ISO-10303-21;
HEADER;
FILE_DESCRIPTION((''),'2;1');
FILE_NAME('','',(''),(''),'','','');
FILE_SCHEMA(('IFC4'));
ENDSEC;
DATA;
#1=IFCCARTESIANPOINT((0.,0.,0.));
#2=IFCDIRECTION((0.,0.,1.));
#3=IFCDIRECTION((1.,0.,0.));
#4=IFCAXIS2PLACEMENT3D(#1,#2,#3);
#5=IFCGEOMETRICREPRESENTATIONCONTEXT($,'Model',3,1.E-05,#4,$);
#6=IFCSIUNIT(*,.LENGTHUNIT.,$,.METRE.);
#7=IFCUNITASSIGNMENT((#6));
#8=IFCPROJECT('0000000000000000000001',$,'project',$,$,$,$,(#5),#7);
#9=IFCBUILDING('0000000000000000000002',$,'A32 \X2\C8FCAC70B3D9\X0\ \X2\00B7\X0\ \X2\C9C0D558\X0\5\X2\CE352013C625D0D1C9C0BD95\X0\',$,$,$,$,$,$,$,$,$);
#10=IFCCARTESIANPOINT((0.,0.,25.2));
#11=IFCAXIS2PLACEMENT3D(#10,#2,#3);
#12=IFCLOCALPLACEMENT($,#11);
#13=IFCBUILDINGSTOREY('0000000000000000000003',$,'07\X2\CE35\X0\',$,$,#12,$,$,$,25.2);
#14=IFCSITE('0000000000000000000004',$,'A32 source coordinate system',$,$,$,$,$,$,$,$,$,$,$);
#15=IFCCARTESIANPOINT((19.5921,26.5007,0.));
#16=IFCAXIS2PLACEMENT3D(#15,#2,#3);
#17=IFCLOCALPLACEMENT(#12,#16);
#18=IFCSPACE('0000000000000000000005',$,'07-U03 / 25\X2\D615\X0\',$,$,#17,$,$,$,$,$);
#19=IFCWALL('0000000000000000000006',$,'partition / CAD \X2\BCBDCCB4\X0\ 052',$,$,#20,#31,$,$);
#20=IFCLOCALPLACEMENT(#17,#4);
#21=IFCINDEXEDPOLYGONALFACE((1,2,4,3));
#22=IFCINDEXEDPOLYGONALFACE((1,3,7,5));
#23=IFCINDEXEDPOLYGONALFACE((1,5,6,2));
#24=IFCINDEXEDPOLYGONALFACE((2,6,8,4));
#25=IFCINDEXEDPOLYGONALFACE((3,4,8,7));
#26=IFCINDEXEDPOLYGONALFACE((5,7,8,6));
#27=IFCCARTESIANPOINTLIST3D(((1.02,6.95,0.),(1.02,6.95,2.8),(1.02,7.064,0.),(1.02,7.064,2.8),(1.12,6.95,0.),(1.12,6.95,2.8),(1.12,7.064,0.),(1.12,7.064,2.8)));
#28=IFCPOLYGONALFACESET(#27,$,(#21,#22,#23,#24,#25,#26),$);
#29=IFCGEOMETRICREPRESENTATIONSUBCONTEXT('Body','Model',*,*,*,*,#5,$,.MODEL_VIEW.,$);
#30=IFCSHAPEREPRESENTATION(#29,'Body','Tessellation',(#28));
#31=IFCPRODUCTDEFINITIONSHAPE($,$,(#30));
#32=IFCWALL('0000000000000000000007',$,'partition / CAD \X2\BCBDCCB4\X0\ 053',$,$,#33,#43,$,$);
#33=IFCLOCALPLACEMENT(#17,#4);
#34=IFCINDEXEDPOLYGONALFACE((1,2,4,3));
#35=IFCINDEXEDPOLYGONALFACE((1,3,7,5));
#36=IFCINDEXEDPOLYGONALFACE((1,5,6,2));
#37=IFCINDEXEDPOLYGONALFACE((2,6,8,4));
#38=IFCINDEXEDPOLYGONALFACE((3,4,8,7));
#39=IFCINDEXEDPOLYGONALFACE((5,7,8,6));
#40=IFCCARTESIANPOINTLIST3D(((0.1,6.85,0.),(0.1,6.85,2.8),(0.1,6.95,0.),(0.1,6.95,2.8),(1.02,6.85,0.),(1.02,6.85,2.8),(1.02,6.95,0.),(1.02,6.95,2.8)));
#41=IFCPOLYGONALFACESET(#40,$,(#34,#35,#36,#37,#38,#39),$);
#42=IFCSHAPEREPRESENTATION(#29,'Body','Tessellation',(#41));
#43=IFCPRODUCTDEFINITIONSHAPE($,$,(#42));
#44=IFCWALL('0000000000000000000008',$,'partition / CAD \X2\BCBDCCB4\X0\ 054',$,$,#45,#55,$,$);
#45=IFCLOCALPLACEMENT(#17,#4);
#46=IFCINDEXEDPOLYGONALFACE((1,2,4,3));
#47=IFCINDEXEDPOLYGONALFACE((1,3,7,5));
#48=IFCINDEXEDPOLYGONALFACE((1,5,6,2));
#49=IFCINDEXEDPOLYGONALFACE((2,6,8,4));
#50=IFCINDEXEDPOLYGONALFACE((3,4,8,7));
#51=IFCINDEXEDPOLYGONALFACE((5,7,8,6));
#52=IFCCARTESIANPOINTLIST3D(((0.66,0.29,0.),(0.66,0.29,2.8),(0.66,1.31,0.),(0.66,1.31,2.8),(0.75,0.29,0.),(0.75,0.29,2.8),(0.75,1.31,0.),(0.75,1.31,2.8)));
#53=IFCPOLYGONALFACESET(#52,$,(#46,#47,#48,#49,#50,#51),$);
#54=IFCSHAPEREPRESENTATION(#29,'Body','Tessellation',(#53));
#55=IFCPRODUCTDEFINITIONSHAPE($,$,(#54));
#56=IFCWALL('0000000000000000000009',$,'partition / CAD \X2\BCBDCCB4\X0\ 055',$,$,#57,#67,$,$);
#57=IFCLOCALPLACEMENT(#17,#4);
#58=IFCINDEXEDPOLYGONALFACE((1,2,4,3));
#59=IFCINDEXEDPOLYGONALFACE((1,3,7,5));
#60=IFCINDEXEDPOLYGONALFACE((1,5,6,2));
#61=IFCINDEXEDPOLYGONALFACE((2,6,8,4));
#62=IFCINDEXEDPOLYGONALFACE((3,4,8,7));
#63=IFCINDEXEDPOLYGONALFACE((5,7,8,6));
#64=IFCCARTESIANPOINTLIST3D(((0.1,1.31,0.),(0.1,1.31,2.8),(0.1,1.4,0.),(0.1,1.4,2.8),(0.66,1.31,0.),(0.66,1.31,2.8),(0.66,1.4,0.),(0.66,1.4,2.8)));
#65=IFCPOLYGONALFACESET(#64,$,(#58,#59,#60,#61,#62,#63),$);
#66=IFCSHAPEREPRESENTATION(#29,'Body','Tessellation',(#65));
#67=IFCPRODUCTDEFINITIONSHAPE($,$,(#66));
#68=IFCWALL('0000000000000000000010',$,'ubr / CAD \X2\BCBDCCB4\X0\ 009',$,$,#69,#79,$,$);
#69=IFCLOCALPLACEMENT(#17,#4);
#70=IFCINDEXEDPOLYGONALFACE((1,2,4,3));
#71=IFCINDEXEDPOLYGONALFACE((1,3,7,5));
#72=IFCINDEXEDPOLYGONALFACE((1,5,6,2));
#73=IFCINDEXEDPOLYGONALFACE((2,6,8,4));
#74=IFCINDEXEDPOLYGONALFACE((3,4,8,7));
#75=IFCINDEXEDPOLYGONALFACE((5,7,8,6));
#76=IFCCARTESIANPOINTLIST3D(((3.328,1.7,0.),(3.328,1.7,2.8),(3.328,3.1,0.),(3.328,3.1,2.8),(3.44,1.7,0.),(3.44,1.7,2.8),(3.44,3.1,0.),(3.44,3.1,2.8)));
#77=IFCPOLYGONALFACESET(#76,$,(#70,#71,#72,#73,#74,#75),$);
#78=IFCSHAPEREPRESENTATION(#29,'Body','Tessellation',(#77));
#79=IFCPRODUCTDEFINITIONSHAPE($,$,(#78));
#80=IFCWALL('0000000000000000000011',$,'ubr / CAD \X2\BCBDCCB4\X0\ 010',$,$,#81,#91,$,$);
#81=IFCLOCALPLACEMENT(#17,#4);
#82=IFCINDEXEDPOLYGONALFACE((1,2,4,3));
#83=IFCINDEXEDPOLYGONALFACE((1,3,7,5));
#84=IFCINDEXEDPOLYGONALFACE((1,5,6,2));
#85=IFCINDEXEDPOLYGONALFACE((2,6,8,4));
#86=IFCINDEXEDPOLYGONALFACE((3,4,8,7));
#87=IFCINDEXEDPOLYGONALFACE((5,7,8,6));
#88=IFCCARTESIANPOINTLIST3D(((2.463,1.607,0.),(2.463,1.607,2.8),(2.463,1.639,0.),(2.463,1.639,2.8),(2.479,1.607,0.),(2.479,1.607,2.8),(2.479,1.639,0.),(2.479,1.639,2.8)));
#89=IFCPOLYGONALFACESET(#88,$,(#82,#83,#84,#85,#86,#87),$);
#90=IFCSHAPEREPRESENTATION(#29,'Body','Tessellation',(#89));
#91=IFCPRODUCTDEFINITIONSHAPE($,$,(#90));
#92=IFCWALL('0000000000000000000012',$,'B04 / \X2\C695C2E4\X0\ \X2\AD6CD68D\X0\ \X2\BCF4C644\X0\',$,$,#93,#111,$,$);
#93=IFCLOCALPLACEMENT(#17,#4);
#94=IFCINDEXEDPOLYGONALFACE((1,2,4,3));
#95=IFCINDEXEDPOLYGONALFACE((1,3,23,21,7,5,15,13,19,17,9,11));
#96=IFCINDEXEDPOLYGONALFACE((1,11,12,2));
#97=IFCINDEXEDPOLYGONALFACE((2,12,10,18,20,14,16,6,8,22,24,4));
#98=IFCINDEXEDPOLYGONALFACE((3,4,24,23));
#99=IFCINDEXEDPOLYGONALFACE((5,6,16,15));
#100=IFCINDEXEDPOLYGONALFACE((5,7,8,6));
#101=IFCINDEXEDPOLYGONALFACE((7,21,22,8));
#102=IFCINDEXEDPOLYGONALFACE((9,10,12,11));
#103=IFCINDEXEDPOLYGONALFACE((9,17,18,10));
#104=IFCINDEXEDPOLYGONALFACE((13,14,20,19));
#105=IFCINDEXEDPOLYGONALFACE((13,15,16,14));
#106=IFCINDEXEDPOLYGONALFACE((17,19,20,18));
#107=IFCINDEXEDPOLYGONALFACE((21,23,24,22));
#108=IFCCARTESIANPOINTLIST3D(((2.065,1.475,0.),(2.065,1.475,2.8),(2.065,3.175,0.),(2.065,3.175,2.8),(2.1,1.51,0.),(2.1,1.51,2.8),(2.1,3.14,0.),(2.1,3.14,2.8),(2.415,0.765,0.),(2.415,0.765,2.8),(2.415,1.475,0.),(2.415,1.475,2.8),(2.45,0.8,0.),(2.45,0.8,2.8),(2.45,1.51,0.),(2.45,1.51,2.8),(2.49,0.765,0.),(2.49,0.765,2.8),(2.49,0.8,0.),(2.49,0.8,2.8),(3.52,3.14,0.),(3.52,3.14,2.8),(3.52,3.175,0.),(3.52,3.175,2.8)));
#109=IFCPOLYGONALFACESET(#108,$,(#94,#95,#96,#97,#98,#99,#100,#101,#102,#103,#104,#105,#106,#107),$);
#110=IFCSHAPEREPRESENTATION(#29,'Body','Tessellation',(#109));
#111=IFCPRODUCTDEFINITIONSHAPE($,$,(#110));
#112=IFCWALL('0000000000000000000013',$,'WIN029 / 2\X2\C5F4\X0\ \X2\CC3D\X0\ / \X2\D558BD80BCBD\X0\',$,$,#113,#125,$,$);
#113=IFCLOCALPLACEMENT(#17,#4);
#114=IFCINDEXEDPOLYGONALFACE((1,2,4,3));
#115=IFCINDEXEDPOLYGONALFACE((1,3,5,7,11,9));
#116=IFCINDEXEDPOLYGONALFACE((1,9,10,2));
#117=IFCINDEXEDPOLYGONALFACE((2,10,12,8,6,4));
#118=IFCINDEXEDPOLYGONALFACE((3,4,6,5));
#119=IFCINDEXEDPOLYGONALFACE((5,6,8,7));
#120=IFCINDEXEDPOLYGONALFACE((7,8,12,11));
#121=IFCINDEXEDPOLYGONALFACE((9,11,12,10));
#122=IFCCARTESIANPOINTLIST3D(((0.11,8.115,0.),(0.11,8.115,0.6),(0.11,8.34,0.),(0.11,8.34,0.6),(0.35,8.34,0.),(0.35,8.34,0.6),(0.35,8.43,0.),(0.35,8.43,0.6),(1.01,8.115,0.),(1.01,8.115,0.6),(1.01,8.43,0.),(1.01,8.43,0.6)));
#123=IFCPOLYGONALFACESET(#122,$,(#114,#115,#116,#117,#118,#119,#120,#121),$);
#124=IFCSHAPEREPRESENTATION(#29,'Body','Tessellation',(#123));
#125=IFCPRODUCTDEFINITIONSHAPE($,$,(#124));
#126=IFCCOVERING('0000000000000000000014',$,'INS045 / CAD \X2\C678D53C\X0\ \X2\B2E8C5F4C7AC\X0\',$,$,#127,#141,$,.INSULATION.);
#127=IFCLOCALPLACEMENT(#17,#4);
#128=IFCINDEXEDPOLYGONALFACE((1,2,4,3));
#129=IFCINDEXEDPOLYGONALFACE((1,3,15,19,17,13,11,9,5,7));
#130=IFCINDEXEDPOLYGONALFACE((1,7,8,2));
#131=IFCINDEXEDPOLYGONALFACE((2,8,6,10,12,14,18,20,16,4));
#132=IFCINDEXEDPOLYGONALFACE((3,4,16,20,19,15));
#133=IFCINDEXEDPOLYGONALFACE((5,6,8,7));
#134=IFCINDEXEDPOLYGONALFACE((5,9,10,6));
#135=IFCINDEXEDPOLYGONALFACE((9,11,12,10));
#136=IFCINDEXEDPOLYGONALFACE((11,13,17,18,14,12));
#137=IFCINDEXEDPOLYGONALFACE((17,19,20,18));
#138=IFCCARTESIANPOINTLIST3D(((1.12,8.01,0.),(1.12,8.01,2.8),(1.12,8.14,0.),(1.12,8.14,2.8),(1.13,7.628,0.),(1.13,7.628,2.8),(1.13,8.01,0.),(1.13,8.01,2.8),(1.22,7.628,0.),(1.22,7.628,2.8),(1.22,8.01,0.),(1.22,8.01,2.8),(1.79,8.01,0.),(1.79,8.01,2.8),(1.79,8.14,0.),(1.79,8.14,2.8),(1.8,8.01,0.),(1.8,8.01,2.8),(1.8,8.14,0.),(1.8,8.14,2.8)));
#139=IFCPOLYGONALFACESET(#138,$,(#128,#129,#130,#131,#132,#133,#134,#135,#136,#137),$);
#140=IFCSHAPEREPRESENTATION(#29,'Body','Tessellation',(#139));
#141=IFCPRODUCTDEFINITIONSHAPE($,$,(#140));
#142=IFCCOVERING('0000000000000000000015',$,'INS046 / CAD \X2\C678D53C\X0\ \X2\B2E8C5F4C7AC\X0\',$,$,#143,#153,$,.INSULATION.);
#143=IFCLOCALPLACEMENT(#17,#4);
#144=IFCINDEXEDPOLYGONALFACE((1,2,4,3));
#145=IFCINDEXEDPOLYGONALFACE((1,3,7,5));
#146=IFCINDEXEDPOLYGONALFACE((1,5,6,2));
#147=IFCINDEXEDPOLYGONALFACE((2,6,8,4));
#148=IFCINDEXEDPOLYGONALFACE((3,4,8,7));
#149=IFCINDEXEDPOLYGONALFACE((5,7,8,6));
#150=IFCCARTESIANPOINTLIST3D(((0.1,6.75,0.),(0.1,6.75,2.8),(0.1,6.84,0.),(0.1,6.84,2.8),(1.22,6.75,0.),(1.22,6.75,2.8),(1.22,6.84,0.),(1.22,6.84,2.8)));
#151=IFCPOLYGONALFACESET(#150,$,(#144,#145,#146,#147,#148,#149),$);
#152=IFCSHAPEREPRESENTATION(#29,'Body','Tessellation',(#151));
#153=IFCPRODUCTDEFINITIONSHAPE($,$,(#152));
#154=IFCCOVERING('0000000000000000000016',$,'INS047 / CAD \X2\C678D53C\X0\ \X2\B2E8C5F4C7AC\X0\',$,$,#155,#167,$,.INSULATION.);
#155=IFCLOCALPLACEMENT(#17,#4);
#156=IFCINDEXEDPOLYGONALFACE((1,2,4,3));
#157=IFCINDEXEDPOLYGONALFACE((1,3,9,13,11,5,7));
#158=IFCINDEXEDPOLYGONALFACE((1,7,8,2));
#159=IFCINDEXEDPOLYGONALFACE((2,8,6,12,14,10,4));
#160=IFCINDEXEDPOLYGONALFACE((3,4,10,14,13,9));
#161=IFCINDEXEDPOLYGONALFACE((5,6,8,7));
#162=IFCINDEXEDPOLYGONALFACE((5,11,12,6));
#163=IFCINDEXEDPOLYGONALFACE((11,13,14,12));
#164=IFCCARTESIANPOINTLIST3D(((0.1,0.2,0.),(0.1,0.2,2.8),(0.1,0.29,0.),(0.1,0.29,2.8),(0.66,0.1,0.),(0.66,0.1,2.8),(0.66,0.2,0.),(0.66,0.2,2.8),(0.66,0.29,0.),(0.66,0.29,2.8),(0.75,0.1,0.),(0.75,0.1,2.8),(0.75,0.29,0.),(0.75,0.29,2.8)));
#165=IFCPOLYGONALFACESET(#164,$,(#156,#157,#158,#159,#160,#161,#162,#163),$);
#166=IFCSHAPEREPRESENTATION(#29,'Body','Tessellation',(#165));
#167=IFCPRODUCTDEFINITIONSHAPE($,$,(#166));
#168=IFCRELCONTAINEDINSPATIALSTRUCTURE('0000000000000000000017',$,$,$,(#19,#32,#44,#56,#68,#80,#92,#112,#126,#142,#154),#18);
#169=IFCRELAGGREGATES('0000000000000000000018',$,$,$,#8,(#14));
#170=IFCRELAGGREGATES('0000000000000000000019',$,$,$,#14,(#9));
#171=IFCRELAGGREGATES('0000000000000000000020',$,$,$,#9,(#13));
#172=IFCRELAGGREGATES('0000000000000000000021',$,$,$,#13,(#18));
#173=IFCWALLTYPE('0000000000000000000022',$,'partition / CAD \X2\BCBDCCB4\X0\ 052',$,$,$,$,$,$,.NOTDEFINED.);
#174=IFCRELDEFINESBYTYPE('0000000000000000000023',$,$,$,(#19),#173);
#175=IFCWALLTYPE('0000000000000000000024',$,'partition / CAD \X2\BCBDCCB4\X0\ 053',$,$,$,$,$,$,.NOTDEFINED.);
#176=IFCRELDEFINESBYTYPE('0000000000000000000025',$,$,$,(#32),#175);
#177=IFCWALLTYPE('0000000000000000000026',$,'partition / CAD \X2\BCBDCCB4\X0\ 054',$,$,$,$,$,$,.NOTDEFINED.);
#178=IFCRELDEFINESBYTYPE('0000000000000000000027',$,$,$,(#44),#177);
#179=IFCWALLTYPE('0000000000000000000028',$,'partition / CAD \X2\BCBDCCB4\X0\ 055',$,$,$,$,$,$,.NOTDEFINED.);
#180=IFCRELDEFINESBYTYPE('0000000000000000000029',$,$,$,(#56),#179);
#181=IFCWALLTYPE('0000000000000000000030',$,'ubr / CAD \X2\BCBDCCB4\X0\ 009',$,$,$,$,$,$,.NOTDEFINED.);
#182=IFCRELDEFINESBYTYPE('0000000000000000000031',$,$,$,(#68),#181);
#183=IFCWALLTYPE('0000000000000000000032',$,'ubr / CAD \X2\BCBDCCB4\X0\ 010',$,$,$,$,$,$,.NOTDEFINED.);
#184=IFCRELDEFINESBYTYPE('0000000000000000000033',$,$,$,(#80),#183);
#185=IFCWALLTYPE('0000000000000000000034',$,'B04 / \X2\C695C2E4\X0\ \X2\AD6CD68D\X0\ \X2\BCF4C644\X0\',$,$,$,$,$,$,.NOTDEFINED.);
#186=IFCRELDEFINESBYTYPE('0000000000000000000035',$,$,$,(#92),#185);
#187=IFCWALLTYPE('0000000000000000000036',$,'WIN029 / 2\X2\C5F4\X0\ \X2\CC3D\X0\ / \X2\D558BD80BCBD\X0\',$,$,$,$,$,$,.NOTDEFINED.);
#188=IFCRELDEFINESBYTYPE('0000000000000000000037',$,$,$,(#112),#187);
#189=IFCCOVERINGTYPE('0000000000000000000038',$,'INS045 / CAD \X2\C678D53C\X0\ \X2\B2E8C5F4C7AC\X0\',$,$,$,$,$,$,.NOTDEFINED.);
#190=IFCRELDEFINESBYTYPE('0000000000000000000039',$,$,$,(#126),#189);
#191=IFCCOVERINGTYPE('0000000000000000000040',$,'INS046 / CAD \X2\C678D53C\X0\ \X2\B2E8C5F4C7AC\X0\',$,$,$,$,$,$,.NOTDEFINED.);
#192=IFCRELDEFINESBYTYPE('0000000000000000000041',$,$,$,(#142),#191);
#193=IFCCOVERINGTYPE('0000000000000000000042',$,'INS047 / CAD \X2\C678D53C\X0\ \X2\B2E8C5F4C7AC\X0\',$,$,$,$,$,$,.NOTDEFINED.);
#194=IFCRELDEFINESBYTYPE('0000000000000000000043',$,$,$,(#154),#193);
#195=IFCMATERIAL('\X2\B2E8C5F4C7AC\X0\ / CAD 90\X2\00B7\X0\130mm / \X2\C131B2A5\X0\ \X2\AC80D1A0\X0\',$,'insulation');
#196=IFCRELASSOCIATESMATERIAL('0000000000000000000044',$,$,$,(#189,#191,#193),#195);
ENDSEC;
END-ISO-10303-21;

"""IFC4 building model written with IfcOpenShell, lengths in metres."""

from ifc_helpers import new_model, si_unit, frame, origin, origin_with_axes, place, context, subcontext, project, spatial, polyline, outline, extrude, source, transform, mapped, material, type_object, type_shapes, element, save


model = new_model("IFC4")

# Units and contexts
model_context = context("Model", 3, precision=1e-05, world=origin_with_axes())
body_context = subcontext(model_context, "Body", "Model", "MODEL_VIEW")
ifc_project = project(units=[si_unit("LENGTHUNIT", "METRE")], contexts=[model_context])

# Site, building, storey, space
storey_placement = place(None, frame((0.0, 0.0, 25.2), z_axis=(0.0, 0.0, 1.0), x_axis=(1.0, 0.0, 0.0)))
space_placement = place(storey_placement, frame((19.5921, 26.5007, 0.0), z_axis=(0.0, 0.0, 1.0), x_axis=(1.0, 0.0, 0.0)))
site = spatial("IfcSite", under=ifc_project, Name="A32 source coordinate system")
building = spatial("IfcBuilding", under=site, Name="A32 주거동 · 지하5층–옥탑지붕")
storey = spatial("IfcBuildingStorey", under=building, at=storey_placement, Name="07층", Elevation=25.2)
space = spatial("IfcSpace", under=storey, at=space_placement, Name="07-U03 / 25형")

# Walls
wall_type_1 = type_object("IfcWallType", Name="partition / CAD 벽체 052", PredefinedType="NOTDEFINED")
shared_shape_1 = source(origin(), body_context, "Body", "SweptSolid", [
    extrude(outline(polyline([(1.12, 6.95), (1.02, 6.95), (1.02, 7.064), (1.12, 7.064), (1.12, 6.95)])), origin(), (0.0, 0.0, 1.0), 2.8),
])
type_shapes(wall_type_1, [shared_shape_1])
wall_1_placement = place(space_placement, origin_with_axes())
element("IfcWall", 1, at=wall_1_placement, inside=space, type_object=wall_type_1, Name="partition / CAD 벽체 052", context=body_context, shape_type="MappedRepresentation", body=[
    mapped(shared_shape_1, transform((0.0, 0.0, 0.0), scale=1.0)),
])
wall_type_2 = type_object("IfcWallType", Name="partition / CAD 벽체 053", PredefinedType="NOTDEFINED")
shared_shape_2 = source(origin(), body_context, "Body", "SweptSolid", [
    extrude(outline(polyline([(1.02, 6.95), (1.02, 6.85), (0.1, 6.85), (0.1, 6.95), (1.02, 6.95)])), origin(), (0.0, 0.0, 1.0), 2.8),
])
type_shapes(wall_type_2, [shared_shape_2])
wall_2_placement = place(space_placement, origin_with_axes())
element("IfcWall", 2, at=wall_2_placement, inside=space, type_object=wall_type_2, Name="partition / CAD 벽체 053", context=body_context, shape_type="MappedRepresentation", body=[
    mapped(shared_shape_2, transform((0.0, 0.0, 0.0), scale=1.0)),
])
wall_type_3 = type_object("IfcWallType", Name="partition / CAD 벽체 054", PredefinedType="NOTDEFINED")
shared_shape_3 = source(origin(), body_context, "Body", "SweptSolid", [
    extrude(outline(polyline([(0.75, 0.29), (0.66, 0.29), (0.66, 1.31), (0.75, 1.31), (0.75, 0.29)])), origin(), (0.0, 0.0, 1.0), 2.8),
])
type_shapes(wall_type_3, [shared_shape_3])
wall_3_placement = place(space_placement, origin_with_axes())
element("IfcWall", 3, at=wall_3_placement, inside=space, type_object=wall_type_3, Name="partition / CAD 벽체 054", context=body_context, shape_type="MappedRepresentation", body=[
    mapped(shared_shape_3, transform((0.0, 0.0, 0.0), scale=1.0)),
])
wall_type_4 = type_object("IfcWallType", Name="partition / CAD 벽체 055", PredefinedType="NOTDEFINED")
shared_shape_4 = source(origin(), body_context, "Body", "SweptSolid", [
    extrude(outline(polyline([(0.66, 1.4), (0.66, 1.31), (0.1, 1.31), (0.1, 1.4), (0.66, 1.4)])), origin(), (0.0, 0.0, 1.0), 2.8),
])
type_shapes(wall_type_4, [shared_shape_4])
wall_4_placement = place(space_placement, origin_with_axes())
element("IfcWall", 4, at=wall_4_placement, inside=space, type_object=wall_type_4, Name="partition / CAD 벽체 055", context=body_context, shape_type="MappedRepresentation", body=[
    mapped(shared_shape_4, transform((0.0, 0.0, 0.0), scale=1.0)),
])
wall_type_5 = type_object("IfcWallType", Name="ubr / CAD 벽체 009", PredefinedType="NOTDEFINED")
shared_shape_5 = source(origin(), body_context, "Body", "SweptSolid", [
    extrude(outline(polyline([(3.328, 3.1), (3.44, 3.1), (3.44, 1.7), (3.328, 1.7), (3.328, 3.1)])), origin(), (0.0, 0.0, 1.0), 2.8),
])
type_shapes(wall_type_5, [shared_shape_5])
wall_5_placement = place(space_placement, origin_with_axes())
element("IfcWall", 5, at=wall_5_placement, inside=space, type_object=wall_type_5, Name="ubr / CAD 벽체 009", context=body_context, shape_type="MappedRepresentation", body=[
    mapped(shared_shape_5, transform((0.0, 0.0, 0.0), scale=1.0)),
])
wall_type_6 = type_object("IfcWallType", Name="ubr / CAD 벽체 010", PredefinedType="NOTDEFINED")
shared_shape_6 = source(origin(), body_context, "Body", "SweptSolid", [
    extrude(outline(polyline([(2.463, 1.607), (2.463, 1.639), (2.479, 1.639), (2.479, 1.607), (2.463, 1.607)])), origin(), (0.0, 0.0, 1.0), 2.8),
])
type_shapes(wall_type_6, [shared_shape_6])
wall_6_placement = place(space_placement, origin_with_axes())
element("IfcWall", 6, at=wall_6_placement, inside=space, type_object=wall_type_6, Name="ubr / CAD 벽체 010", context=body_context, shape_type="MappedRepresentation", body=[
    mapped(shared_shape_6, transform((0.0, 0.0, 0.0), scale=1.0)),
])
wall_type_7 = type_object("IfcWallType", Name="B04 / 욕실 구획 보완", PredefinedType="NOTDEFINED")
shared_shape_7 = source(origin(), body_context, "Body", "SweptSolid", [
    extrude(outline(polyline([(3.52, 3.175), (3.52, 3.14), (2.1, 3.14), (2.1, 1.51), (2.45, 1.51), (2.45, 0.8), (2.49, 0.8), (2.49, 0.765), (2.415, 0.765), (2.415, 1.475), (2.065, 1.475), (2.065, 3.175), (3.52, 3.175)])), origin(), (0.0, 0.0, 1.0), 2.8),
])
type_shapes(wall_type_7, [shared_shape_7])
wall_7_placement = place(space_placement, origin_with_axes())
element("IfcWall", 7, at=wall_7_placement, inside=space, type_object=wall_type_7, Name="B04 / 욕실 구획 보완", context=body_context, shape_type="MappedRepresentation", body=[
    mapped(shared_shape_7, transform((0.0, 0.0, 0.0), scale=1.0)),
])
wall_type_8 = type_object("IfcWallType", Name="WIN029 / 2열 창 / 하부벽", PredefinedType="NOTDEFINED")
shared_shape_8 = source(origin(), body_context, "Body", "SweptSolid", [
    extrude(outline(polyline([(1.01, 8.115), (0.11, 8.115), (0.11, 8.34), (0.35, 8.34), (0.35, 8.43), (1.01, 8.43), (1.01, 8.115)])), origin(), (0.0, 0.0, 1.0), 0.6),
])
type_shapes(wall_type_8, [shared_shape_8])
wall_8_placement = place(space_placement, origin_with_axes())
element("IfcWall", 8, at=wall_8_placement, inside=space, type_object=wall_type_8, Name="WIN029 / 2열 창 / 하부벽", context=body_context, shape_type="MappedRepresentation", body=[
    mapped(shared_shape_8, transform((0.0, 0.0, 0.0), scale=1.0)),
])

# Coverings
ifc_material = material(Name="단열재 / CAD 90·130mm / 성능 검토", Category="insulation")
covering_type_1 = type_object("IfcCoveringType", Name="INS045 / CAD 외피 단열재", PredefinedType="NOTDEFINED", material=ifc_material)
shared_shape_9 = source(origin(), body_context, "Body", "SweptSolid", [
    extrude(outline(polyline([(1.22, 8.01), (1.22, 7.628), (1.13, 7.628), (1.13, 8.01), (1.12, 8.01), (1.12, 8.14), (1.79, 8.14), (1.8, 8.14), (1.8, 8.01), (1.79, 8.01), (1.22, 8.01)])), origin(), (0.0, 0.0, 1.0), 2.8),
])
type_shapes(covering_type_1, [shared_shape_9])
covering_1_placement = place(space_placement, origin_with_axes())
element("IfcCovering", 9, at=covering_1_placement, inside=space, type_object=covering_type_1, Name="INS045 / CAD 외피 단열재", PredefinedType="INSULATION", context=body_context, shape_type="MappedRepresentation", body=[
    mapped(shared_shape_9, transform((0.0, 0.0, 0.0), scale=1.0)),
])
covering_type_2 = type_object("IfcCoveringType", Name="INS046 / CAD 외피 단열재", PredefinedType="NOTDEFINED", material=ifc_material)
shared_shape_10 = source(origin(), body_context, "Body", "SweptSolid", [
    extrude(outline(polyline([(0.1, 6.84), (1.22, 6.84), (1.22, 6.75), (0.1, 6.75), (0.1, 6.84)])), origin(), (0.0, 0.0, 1.0), 2.8),
])
type_shapes(covering_type_2, [shared_shape_10])
covering_2_placement = place(space_placement, origin_with_axes())
element("IfcCovering", 10, at=covering_2_placement, inside=space, type_object=covering_type_2, Name="INS046 / CAD 외피 단열재", PredefinedType="INSULATION", context=body_context, shape_type="MappedRepresentation", body=[
    mapped(shared_shape_10, transform((0.0, 0.0, 0.0), scale=1.0)),
])
covering_type_3 = type_object("IfcCoveringType", Name="INS047 / CAD 외피 단열재", PredefinedType="NOTDEFINED", material=ifc_material)
shared_shape_11 = source(origin(), body_context, "Body", "SweptSolid", [
    extrude(outline(polyline([(0.1, 0.2), (0.1, 0.29), (0.66, 0.29), (0.75, 0.29), (0.75, 0.1), (0.66, 0.1), (0.66, 0.2), (0.1, 0.2)])), origin(), (0.0, 0.0, 1.0), 2.8),
])
type_shapes(covering_type_3, [shared_shape_11])
covering_3_placement = place(space_placement, origin_with_axes())
element("IfcCovering", 11, at=covering_3_placement, inside=space, type_object=covering_type_3, Name="INS047 / CAD 외피 단열재", PredefinedType="INSULATION", context=body_context, shape_type="MappedRepresentation", body=[
    mapped(shared_shape_11, transform((0.0, 0.0, 0.0), scale=1.0)),
])

save(model, "model.ifc")
